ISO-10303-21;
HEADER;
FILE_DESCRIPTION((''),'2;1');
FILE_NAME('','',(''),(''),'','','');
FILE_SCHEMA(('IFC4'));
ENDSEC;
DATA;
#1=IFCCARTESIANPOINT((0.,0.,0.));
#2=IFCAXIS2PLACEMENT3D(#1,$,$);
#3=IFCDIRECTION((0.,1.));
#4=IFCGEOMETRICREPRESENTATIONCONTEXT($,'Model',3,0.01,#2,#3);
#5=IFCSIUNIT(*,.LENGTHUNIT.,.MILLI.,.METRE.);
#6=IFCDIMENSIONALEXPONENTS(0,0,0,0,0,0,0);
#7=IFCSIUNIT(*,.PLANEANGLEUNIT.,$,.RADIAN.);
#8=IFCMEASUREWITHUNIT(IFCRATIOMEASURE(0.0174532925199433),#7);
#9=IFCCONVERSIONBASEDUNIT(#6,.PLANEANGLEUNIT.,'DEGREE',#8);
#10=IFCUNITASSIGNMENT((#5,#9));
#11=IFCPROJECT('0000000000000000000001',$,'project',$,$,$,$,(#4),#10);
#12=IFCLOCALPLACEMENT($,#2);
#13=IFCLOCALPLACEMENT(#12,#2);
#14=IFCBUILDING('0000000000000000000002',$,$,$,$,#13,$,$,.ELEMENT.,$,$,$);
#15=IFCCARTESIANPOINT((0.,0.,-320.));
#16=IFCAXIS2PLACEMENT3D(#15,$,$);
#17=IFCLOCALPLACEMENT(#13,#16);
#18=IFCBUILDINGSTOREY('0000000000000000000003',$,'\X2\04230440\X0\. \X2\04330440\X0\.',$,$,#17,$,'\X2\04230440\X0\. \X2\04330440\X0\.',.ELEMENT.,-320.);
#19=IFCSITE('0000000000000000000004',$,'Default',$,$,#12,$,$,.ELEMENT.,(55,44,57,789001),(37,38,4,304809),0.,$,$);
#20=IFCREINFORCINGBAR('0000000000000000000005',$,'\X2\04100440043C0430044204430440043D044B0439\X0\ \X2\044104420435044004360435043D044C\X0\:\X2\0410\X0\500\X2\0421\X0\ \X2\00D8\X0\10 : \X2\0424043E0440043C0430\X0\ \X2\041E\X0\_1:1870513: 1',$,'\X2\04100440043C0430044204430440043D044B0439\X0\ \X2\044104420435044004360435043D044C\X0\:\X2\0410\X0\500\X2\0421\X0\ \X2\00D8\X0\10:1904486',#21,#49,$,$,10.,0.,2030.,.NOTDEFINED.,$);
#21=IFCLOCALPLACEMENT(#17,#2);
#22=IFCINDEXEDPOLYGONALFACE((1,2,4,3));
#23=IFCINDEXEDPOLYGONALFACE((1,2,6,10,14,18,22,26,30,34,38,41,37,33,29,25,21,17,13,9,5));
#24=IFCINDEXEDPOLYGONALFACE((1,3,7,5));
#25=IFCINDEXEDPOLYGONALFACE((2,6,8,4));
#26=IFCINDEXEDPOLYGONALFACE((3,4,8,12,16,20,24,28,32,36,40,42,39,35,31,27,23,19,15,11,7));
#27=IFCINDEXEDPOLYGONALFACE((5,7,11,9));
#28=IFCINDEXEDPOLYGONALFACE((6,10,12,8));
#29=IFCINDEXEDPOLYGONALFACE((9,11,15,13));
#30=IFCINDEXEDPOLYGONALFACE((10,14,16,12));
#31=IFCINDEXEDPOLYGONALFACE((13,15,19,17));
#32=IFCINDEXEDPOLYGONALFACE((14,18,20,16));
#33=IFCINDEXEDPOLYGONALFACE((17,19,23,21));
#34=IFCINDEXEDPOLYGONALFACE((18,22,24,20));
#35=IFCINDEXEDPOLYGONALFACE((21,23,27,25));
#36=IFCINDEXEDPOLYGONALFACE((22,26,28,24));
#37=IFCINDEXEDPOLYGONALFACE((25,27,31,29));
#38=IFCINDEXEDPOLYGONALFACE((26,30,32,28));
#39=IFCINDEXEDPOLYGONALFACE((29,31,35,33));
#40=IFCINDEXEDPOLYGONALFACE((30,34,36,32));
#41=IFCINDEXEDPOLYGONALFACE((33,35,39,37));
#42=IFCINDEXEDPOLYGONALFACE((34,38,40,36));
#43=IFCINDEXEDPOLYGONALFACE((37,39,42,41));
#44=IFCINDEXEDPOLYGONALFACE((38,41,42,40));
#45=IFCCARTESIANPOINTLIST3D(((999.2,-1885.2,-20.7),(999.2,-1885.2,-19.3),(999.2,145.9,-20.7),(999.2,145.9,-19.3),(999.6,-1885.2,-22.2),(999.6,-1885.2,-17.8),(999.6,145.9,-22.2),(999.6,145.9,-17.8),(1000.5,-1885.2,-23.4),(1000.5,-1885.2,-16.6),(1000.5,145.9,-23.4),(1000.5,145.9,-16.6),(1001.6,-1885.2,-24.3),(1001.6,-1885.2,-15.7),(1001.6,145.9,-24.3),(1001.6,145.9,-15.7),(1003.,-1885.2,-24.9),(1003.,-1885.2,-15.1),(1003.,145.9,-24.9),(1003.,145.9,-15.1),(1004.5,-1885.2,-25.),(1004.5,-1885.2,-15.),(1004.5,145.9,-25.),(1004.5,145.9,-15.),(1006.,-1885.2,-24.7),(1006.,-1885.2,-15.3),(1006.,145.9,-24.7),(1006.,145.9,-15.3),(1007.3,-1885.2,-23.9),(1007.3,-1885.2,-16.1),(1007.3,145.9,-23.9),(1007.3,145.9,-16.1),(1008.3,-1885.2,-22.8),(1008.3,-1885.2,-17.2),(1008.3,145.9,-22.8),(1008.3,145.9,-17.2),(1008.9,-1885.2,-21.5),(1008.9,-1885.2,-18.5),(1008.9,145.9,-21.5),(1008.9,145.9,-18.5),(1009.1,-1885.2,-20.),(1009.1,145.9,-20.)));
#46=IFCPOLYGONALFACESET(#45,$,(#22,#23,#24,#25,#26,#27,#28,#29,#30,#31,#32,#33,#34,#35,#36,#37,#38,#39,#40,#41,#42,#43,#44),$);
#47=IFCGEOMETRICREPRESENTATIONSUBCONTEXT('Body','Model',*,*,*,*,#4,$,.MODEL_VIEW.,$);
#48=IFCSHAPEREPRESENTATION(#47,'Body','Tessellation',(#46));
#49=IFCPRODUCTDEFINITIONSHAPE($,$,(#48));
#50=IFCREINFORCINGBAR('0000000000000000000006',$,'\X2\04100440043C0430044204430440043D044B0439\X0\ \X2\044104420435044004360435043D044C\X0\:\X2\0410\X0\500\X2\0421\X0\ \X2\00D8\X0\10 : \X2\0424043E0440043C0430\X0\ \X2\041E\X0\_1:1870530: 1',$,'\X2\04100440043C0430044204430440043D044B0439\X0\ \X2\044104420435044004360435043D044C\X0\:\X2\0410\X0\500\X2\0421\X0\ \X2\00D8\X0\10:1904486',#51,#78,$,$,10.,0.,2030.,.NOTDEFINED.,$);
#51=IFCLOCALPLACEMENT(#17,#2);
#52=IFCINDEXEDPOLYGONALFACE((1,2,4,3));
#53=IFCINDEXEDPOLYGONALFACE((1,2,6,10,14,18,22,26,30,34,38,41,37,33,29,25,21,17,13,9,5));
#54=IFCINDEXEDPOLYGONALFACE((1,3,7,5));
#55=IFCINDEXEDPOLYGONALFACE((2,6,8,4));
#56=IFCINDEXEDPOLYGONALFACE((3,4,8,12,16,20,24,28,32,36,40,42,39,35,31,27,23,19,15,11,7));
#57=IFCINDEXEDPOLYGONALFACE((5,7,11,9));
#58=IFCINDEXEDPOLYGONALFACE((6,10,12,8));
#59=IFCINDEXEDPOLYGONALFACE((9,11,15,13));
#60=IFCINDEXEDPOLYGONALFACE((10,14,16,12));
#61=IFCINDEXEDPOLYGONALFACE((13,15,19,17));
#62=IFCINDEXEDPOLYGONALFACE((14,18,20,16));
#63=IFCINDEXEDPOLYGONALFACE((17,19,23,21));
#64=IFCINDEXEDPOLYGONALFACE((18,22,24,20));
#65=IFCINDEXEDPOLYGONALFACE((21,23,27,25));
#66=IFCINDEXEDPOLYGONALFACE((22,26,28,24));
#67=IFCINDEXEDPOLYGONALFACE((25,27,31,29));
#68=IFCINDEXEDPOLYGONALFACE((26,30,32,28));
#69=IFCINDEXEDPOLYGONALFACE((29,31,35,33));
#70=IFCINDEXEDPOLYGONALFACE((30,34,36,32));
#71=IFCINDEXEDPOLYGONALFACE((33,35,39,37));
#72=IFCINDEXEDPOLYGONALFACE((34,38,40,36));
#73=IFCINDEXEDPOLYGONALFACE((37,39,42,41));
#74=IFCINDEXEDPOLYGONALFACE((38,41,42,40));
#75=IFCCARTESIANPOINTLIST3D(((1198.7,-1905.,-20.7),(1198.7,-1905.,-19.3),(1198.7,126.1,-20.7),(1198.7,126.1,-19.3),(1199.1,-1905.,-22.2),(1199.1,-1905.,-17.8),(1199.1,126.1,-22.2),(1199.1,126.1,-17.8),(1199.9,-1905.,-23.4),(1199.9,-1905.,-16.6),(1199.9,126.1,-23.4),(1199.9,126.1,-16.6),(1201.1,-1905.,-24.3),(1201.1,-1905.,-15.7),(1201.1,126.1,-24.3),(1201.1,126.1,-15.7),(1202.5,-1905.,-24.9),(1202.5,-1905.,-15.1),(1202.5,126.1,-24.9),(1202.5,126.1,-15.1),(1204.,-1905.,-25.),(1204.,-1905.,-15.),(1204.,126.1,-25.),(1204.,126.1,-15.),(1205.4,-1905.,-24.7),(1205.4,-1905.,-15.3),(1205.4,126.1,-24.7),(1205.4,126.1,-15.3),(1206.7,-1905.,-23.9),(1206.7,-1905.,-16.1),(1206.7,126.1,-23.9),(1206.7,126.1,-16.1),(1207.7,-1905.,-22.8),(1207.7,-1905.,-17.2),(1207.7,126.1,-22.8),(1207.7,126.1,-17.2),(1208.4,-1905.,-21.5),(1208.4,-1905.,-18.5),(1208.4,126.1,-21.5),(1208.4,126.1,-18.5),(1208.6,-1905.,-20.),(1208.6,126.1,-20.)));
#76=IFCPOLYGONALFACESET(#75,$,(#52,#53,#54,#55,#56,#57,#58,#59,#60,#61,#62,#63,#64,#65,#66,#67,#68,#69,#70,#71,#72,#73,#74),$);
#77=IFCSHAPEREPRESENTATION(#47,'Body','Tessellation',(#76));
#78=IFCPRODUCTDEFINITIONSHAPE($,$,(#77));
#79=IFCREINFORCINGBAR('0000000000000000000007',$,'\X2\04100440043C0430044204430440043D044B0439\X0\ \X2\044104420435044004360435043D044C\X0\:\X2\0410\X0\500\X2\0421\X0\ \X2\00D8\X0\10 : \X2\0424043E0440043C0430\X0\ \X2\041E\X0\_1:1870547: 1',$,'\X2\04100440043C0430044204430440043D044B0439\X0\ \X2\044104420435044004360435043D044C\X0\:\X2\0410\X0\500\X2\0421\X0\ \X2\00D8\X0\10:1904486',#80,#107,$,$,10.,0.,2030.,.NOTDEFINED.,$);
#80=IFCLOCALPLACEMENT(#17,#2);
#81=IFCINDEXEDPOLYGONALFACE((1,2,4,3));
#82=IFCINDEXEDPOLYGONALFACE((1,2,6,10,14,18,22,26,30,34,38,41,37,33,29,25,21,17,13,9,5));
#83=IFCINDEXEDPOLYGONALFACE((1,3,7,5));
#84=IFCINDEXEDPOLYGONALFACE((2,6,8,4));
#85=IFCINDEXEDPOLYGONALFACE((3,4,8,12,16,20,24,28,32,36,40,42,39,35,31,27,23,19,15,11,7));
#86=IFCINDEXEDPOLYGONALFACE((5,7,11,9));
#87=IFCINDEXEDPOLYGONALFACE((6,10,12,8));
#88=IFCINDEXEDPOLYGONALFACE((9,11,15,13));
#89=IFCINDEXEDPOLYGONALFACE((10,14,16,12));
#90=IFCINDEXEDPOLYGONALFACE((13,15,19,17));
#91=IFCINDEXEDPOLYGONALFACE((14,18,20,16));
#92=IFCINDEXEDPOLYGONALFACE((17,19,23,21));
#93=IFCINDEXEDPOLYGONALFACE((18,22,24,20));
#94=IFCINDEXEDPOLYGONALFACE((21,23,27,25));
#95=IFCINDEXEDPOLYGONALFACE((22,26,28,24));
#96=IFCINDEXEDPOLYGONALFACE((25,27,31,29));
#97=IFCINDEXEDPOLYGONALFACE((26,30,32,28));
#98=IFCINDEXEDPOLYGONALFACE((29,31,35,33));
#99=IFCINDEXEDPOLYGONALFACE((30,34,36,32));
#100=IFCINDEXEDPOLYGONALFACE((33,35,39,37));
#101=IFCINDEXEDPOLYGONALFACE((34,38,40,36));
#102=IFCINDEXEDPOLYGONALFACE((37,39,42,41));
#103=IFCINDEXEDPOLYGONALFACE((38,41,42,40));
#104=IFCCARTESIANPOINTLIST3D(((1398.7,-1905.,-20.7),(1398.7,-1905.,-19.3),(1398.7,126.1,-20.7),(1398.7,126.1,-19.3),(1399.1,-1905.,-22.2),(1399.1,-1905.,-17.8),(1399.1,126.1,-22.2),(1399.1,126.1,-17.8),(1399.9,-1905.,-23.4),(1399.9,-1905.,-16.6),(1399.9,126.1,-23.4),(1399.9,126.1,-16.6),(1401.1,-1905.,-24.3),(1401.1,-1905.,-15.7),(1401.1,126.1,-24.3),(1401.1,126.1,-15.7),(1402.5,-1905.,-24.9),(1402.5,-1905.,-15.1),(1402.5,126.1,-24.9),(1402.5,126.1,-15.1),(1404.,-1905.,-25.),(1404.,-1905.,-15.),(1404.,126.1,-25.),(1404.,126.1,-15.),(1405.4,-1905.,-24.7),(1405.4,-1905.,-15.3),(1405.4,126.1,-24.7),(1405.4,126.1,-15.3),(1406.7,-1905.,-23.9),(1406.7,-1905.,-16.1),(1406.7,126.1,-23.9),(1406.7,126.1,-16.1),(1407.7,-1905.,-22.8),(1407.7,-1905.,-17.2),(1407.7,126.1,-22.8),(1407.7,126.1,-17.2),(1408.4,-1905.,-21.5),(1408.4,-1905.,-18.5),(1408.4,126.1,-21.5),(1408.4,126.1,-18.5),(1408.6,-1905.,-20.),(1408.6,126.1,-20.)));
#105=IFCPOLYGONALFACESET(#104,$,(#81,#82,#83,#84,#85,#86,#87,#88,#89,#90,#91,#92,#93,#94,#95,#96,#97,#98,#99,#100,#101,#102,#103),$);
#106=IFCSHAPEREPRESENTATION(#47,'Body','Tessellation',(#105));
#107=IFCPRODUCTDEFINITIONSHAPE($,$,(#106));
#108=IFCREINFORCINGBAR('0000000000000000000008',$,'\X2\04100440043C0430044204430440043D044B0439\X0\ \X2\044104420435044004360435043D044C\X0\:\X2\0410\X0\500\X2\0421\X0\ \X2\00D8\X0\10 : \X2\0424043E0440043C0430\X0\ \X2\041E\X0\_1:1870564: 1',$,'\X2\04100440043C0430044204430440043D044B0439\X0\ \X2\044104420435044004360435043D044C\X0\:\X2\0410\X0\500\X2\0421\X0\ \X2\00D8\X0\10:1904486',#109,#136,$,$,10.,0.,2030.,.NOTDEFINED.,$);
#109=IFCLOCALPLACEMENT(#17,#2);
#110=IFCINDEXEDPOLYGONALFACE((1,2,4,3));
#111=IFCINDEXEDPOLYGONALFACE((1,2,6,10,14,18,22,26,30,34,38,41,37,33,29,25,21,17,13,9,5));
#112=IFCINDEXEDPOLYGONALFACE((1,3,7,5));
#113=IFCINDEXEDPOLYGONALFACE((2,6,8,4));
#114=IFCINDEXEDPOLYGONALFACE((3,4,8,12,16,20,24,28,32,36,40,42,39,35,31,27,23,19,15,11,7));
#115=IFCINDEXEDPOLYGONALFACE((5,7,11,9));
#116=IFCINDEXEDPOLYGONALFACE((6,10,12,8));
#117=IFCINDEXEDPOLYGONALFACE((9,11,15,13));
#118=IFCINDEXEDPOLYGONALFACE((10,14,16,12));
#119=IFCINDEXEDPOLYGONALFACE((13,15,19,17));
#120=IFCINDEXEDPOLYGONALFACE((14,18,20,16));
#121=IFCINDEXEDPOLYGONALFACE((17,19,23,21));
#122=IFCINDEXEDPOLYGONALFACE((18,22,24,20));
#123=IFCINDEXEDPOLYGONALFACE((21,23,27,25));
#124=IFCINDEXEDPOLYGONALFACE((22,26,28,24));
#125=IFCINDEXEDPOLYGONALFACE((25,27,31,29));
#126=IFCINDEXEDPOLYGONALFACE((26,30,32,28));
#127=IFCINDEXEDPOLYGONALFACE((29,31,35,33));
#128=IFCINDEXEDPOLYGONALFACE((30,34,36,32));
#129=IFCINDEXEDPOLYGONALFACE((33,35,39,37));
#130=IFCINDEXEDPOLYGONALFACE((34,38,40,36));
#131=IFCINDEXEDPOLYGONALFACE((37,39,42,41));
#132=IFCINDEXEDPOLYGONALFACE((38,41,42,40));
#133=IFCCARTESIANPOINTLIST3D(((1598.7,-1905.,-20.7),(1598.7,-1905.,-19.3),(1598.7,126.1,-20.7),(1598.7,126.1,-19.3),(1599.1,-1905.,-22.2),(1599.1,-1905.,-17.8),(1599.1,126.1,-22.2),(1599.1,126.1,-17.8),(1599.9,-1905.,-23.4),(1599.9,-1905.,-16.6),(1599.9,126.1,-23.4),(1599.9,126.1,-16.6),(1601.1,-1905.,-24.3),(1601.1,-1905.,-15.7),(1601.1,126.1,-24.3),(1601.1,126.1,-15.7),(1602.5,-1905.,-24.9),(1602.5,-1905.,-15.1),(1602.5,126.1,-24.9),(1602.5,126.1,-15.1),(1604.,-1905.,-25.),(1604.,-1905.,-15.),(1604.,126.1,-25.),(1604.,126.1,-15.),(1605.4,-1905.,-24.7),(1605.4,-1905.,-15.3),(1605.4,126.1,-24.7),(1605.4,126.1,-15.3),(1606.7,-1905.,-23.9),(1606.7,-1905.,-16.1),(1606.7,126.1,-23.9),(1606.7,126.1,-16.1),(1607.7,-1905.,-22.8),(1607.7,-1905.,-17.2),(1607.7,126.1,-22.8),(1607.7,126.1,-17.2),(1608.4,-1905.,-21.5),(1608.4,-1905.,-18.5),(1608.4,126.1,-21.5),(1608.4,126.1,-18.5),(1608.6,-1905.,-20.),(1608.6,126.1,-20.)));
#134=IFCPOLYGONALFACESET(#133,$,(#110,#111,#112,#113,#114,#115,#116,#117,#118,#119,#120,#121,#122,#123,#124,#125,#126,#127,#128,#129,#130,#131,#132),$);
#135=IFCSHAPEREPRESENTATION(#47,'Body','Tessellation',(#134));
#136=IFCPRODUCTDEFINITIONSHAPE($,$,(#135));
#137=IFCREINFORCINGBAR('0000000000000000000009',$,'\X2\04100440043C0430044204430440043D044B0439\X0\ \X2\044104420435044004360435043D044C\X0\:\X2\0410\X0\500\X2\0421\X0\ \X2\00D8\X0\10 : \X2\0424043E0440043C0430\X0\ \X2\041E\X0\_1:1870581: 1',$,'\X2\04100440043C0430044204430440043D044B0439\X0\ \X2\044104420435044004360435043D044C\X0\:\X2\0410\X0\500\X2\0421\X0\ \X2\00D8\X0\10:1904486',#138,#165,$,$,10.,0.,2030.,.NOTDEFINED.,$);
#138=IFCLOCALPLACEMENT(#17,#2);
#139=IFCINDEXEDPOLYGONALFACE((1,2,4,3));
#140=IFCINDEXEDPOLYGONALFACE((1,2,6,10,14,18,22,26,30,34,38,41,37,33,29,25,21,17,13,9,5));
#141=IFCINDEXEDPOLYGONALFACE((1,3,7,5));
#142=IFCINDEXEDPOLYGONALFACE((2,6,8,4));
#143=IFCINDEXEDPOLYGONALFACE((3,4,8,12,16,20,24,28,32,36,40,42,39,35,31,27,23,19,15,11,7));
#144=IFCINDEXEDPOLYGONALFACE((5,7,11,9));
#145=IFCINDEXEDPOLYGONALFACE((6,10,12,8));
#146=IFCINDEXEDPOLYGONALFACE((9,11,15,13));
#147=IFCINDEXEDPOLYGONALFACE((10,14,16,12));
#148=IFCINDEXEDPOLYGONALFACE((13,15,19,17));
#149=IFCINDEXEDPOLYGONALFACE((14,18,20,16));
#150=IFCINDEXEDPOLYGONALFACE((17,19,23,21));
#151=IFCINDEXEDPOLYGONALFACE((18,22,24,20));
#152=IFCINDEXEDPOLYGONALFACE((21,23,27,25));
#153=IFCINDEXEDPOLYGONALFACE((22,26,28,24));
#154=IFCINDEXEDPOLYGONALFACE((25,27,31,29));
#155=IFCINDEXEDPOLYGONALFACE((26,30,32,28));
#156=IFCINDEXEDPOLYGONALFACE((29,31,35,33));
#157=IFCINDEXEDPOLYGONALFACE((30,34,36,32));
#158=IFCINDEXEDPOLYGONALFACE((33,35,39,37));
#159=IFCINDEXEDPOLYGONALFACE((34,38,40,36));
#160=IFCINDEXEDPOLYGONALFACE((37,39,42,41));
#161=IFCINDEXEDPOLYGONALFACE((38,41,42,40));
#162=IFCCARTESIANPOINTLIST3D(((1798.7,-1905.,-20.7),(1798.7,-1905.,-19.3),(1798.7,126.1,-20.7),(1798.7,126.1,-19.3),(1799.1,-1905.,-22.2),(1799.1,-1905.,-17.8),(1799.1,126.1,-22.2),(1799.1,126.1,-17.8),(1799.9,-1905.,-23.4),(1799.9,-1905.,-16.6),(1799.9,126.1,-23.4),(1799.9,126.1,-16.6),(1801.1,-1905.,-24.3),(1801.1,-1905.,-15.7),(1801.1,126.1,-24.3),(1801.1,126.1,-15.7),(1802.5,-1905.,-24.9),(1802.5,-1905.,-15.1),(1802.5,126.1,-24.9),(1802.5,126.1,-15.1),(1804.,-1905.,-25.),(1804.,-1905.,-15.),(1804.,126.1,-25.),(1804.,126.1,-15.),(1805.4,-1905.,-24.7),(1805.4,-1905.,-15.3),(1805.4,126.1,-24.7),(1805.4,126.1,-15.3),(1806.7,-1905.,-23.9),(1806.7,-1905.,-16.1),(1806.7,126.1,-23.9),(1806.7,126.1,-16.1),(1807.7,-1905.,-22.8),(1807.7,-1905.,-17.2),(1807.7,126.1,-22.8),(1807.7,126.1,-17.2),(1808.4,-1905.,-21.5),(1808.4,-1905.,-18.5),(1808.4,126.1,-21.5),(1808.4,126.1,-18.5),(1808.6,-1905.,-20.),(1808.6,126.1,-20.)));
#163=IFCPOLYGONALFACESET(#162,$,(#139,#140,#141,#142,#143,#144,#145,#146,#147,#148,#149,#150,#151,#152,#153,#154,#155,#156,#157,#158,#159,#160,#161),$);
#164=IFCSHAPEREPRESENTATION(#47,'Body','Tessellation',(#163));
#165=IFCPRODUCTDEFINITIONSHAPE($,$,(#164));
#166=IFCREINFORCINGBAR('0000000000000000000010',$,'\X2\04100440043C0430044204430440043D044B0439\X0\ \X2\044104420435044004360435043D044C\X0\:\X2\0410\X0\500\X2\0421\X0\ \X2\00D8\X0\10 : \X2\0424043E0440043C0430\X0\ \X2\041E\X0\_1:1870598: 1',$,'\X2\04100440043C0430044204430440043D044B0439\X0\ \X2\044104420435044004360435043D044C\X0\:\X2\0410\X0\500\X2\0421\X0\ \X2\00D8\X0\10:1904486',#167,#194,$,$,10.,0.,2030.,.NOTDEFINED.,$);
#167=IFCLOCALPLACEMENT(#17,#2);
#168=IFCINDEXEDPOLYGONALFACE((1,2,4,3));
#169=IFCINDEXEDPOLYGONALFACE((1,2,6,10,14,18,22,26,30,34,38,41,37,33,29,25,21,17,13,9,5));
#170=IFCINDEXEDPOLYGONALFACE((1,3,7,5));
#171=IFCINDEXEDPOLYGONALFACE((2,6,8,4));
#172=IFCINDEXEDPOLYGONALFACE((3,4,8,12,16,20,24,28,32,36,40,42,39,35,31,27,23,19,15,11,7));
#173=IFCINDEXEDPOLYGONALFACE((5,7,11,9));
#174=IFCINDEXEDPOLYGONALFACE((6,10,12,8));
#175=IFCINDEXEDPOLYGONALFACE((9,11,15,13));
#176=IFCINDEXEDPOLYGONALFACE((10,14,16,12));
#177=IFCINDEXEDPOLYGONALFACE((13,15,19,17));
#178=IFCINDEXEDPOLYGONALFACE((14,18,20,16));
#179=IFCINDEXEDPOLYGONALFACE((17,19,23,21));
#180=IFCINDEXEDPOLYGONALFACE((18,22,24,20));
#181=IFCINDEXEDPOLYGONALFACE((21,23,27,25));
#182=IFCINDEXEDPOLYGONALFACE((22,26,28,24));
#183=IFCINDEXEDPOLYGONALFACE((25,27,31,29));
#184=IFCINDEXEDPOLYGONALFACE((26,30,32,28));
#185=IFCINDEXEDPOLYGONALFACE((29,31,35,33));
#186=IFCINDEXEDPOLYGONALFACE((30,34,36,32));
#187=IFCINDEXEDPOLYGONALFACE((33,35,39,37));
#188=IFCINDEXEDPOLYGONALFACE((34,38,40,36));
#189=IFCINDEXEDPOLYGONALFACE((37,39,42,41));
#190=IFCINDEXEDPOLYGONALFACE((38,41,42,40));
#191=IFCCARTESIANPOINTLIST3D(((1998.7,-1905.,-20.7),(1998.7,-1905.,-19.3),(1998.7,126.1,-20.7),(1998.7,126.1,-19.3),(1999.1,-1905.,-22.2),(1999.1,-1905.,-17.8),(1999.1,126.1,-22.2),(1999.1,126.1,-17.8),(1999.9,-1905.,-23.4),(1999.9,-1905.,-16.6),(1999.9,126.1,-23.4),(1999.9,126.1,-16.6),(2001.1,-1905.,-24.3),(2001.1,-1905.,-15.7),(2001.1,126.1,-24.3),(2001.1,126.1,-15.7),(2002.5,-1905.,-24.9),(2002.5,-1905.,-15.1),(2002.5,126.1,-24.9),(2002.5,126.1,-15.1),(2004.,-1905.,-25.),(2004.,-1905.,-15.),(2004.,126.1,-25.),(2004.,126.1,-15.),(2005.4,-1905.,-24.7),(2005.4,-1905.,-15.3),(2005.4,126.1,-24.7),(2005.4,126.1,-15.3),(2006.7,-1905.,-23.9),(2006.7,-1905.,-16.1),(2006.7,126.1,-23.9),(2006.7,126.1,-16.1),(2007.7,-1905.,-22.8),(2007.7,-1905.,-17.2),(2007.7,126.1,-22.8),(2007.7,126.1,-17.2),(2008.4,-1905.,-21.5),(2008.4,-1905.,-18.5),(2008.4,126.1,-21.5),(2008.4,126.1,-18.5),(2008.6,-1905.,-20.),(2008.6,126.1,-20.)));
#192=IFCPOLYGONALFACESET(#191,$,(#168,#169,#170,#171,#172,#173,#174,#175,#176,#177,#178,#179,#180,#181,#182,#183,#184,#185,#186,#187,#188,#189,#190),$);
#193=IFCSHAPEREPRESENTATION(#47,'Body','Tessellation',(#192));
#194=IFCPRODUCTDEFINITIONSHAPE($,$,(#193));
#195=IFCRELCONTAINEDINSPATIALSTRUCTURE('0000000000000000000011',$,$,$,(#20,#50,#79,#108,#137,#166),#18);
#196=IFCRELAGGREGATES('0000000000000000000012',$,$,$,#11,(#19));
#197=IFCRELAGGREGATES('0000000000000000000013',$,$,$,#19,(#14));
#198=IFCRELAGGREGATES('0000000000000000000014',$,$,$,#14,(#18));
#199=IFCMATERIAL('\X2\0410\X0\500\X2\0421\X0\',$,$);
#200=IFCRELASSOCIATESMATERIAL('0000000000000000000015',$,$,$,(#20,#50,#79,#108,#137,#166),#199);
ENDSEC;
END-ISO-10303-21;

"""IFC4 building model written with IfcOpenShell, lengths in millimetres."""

from ifc_helpers import new_model, entity, si_unit, converted_unit, direction, frame, origin, place, context, subcontext, project, spatial, material, element, save


model = new_model("IFC4")

# Units and contexts
model_context = context("Model", 3, precision=0.01, world=origin(), true_north=direction((0.0, 1.0)))
body_context = subcontext(model_context, "Body", "Model", "MODEL_VIEW")
ifc_project = project(units=[si_unit("LENGTHUNIT", "METRE", prefix="MILLI"), converted_unit("PLANEANGLEUNIT", "DEGREE", entity("IfcRatioMeasure", 0.0174532925199433), si_unit("PLANEANGLEUNIT", "RADIAN"), dimensions=[0, 0, 0, 0, 0, 0, 0])], contexts=[model_context])

# Site, building, storey
site_placement = place(None, origin())
site = spatial("IfcSite", under=ifc_project, at=site_placement, Name="Default", CompositionType="ELEMENT", RefLatitude=(55, 44, 57, 789001), RefLongitude=(37, 38, 4, 304809), RefElevation=0.0)
building_placement = place(site_placement, origin())
building = spatial("IfcBuilding", under=site, at=building_placement, CompositionType="ELEMENT")
storey_placement = place(building_placement, frame((0.0, 0.0, -320.0)))
storey = spatial("IfcBuildingStorey", under=building, at=storey_placement, Name="Ур. гр.", LongName="Ур. гр.", CompositionType="ELEMENT", Elevation=-320.0)

# Reinforcing bars
ifc_material_1 = material(Name="А500С")
reinforcing_bar_1_placement = place(storey_placement, origin())
element("IfcReinforcingBar", 1, at=reinforcing_bar_1_placement, inside=storey, material=ifc_material_1, Name="Арматурный стержень:А500С Ø10 : Форма О_1:1870513: 1", ObjectType="Арматурный стержень:А500С Ø10:1904486", BarLength=2030.0, CrossSectionArea=0.0, NominalDiameter=10.0, PredefinedType="NOTDEFINED", context=body_context, shape_type="AdvancedSweptSolid", body=[
    entity("IfcSweptDiskSolid", entity("IfcCompositeCurve", [entity("IfcCompositeCurveSegment", "CONTINUOUS", True, entity("IfcPolyline", [entity("IfcCartesianPoint", [1004.1, -1885.2, -20.0]), entity("IfcCartesianPoint", [1004.1, 145.9, -20.0])]))], False), 5.0, None, 0.0, 1.0),
])
reinforcing_bar_2_placement = place(storey_placement, origin())
element("IfcReinforcingBar", 2, at=reinforcing_bar_2_placement, inside=storey, material=ifc_material_1, Name="Арматурный стержень:А500С Ø10 : Форма О_1:1870530: 1", ObjectType="Арматурный стержень:А500С Ø10:1904486", BarLength=2030.0, CrossSectionArea=0.0, NominalDiameter=10.0, PredefinedType="NOTDEFINED", context=body_context, shape_type="AdvancedSweptSolid", body=[
    entity("IfcSweptDiskSolid", entity("IfcCompositeCurve", [entity("IfcCompositeCurveSegment", "CONTINUOUS", True, entity("IfcPolyline", [entity("IfcCartesianPoint", [1203.6, -1905.0, -20.0]), entity("IfcCartesianPoint", [1203.6, 126.1, -20.0])]))], False), 5.0, None, 0.0, 1.0),
])
reinforcing_bar_3_placement = place(storey_placement, origin())
element("IfcReinforcingBar", 3, at=reinforcing_bar_3_placement, inside=storey, material=ifc_material_1, Name="Арматурный стержень:А500С Ø10 : Форма О_1:1870547: 1", ObjectType="Арматурный стержень:А500С Ø10:1904486", BarLength=2030.0, CrossSectionArea=0.0, NominalDiameter=10.0, PredefinedType="NOTDEFINED", context=body_context, shape_type="AdvancedSweptSolid", body=[
    entity("IfcSweptDiskSolid", entity("IfcCompositeCurve", [entity("IfcCompositeCurveSegment", "CONTINUOUS", True, entity("IfcPolyline", [entity("IfcCartesianPoint", [1403.6, -1905.0, -20.0]), entity("IfcCartesianPoint", [1403.6, 126.1, -20.0])]))], False), 5.0, None, 0.0, 1.0),
])
reinforcing_bar_4_placement = place(storey_placement, origin())
element("IfcReinforcingBar", 4, at=reinforcing_bar_4_placement, inside=storey, material=ifc_material_1, Name="Арматурный стержень:А500С Ø10 : Форма О_1:1870564: 1", ObjectType="Арматурный стержень:А500С Ø10:1904486", BarLength=2030.0, CrossSectionArea=0.0, NominalDiameter=10.0, PredefinedType="NOTDEFINED", context=body_context, shape_type="AdvancedSweptSolid", body=[
    entity("IfcSweptDiskSolid", entity("IfcCompositeCurve", [entity("IfcCompositeCurveSegment", "CONTINUOUS", True, entity("IfcPolyline", [entity("IfcCartesianPoint", [1603.6, -1905.0, -20.0]), entity("IfcCartesianPoint", [1603.6, 126.1, -20.0])]))], False), 5.0, None, 0.0, 1.0),
])
reinforcing_bar_5_placement = place(storey_placement, origin())
element("IfcReinforcingBar", 5, at=reinforcing_bar_5_placement, inside=storey, material=ifc_material_1, Name="Арматурный стержень:А500С Ø10 : Форма О_1:1870581: 1", ObjectType="Арматурный стержень:А500С Ø10:1904486", BarLength=2030.0, CrossSectionArea=0.0, NominalDiameter=10.0, PredefinedType="NOTDEFINED", context=body_context, shape_type="AdvancedSweptSolid", body=[
    entity("IfcSweptDiskSolid", entity("IfcCompositeCurve", [entity("IfcCompositeCurveSegment", "CONTINUOUS", True, entity("IfcPolyline", [entity("IfcCartesianPoint", [1803.6, -1905.0, -20.0]), entity("IfcCartesianPoint", [1803.6, 126.1, -20.0])]))], False), 5.0, None, 0.0, 1.0),
])
reinforcing_bar_6_placement = place(storey_placement, origin())
element("IfcReinforcingBar", 6, at=reinforcing_bar_6_placement, inside=storey, material=ifc_material_1, Name="Арматурный стержень:А500С Ø10 : Форма О_1:1870598: 1", ObjectType="Арматурный стержень:А500С Ø10:1904486", BarLength=2030.0, CrossSectionArea=0.0, NominalDiameter=10.0, PredefinedType="NOTDEFINED", context=body_context, shape_type="AdvancedSweptSolid", body=[
    entity("IfcSweptDiskSolid", entity("IfcCompositeCurve", [entity("IfcCompositeCurveSegment", "CONTINUOUS", True, entity("IfcPolyline", [entity("IfcCartesianPoint", [2003.6, -1905.0, -20.0]), entity("IfcCartesianPoint", [2003.6, 126.1, -20.0])]))], False), 5.0, None, 0.0, 1.0),
])

save(model, "model.ifc")
